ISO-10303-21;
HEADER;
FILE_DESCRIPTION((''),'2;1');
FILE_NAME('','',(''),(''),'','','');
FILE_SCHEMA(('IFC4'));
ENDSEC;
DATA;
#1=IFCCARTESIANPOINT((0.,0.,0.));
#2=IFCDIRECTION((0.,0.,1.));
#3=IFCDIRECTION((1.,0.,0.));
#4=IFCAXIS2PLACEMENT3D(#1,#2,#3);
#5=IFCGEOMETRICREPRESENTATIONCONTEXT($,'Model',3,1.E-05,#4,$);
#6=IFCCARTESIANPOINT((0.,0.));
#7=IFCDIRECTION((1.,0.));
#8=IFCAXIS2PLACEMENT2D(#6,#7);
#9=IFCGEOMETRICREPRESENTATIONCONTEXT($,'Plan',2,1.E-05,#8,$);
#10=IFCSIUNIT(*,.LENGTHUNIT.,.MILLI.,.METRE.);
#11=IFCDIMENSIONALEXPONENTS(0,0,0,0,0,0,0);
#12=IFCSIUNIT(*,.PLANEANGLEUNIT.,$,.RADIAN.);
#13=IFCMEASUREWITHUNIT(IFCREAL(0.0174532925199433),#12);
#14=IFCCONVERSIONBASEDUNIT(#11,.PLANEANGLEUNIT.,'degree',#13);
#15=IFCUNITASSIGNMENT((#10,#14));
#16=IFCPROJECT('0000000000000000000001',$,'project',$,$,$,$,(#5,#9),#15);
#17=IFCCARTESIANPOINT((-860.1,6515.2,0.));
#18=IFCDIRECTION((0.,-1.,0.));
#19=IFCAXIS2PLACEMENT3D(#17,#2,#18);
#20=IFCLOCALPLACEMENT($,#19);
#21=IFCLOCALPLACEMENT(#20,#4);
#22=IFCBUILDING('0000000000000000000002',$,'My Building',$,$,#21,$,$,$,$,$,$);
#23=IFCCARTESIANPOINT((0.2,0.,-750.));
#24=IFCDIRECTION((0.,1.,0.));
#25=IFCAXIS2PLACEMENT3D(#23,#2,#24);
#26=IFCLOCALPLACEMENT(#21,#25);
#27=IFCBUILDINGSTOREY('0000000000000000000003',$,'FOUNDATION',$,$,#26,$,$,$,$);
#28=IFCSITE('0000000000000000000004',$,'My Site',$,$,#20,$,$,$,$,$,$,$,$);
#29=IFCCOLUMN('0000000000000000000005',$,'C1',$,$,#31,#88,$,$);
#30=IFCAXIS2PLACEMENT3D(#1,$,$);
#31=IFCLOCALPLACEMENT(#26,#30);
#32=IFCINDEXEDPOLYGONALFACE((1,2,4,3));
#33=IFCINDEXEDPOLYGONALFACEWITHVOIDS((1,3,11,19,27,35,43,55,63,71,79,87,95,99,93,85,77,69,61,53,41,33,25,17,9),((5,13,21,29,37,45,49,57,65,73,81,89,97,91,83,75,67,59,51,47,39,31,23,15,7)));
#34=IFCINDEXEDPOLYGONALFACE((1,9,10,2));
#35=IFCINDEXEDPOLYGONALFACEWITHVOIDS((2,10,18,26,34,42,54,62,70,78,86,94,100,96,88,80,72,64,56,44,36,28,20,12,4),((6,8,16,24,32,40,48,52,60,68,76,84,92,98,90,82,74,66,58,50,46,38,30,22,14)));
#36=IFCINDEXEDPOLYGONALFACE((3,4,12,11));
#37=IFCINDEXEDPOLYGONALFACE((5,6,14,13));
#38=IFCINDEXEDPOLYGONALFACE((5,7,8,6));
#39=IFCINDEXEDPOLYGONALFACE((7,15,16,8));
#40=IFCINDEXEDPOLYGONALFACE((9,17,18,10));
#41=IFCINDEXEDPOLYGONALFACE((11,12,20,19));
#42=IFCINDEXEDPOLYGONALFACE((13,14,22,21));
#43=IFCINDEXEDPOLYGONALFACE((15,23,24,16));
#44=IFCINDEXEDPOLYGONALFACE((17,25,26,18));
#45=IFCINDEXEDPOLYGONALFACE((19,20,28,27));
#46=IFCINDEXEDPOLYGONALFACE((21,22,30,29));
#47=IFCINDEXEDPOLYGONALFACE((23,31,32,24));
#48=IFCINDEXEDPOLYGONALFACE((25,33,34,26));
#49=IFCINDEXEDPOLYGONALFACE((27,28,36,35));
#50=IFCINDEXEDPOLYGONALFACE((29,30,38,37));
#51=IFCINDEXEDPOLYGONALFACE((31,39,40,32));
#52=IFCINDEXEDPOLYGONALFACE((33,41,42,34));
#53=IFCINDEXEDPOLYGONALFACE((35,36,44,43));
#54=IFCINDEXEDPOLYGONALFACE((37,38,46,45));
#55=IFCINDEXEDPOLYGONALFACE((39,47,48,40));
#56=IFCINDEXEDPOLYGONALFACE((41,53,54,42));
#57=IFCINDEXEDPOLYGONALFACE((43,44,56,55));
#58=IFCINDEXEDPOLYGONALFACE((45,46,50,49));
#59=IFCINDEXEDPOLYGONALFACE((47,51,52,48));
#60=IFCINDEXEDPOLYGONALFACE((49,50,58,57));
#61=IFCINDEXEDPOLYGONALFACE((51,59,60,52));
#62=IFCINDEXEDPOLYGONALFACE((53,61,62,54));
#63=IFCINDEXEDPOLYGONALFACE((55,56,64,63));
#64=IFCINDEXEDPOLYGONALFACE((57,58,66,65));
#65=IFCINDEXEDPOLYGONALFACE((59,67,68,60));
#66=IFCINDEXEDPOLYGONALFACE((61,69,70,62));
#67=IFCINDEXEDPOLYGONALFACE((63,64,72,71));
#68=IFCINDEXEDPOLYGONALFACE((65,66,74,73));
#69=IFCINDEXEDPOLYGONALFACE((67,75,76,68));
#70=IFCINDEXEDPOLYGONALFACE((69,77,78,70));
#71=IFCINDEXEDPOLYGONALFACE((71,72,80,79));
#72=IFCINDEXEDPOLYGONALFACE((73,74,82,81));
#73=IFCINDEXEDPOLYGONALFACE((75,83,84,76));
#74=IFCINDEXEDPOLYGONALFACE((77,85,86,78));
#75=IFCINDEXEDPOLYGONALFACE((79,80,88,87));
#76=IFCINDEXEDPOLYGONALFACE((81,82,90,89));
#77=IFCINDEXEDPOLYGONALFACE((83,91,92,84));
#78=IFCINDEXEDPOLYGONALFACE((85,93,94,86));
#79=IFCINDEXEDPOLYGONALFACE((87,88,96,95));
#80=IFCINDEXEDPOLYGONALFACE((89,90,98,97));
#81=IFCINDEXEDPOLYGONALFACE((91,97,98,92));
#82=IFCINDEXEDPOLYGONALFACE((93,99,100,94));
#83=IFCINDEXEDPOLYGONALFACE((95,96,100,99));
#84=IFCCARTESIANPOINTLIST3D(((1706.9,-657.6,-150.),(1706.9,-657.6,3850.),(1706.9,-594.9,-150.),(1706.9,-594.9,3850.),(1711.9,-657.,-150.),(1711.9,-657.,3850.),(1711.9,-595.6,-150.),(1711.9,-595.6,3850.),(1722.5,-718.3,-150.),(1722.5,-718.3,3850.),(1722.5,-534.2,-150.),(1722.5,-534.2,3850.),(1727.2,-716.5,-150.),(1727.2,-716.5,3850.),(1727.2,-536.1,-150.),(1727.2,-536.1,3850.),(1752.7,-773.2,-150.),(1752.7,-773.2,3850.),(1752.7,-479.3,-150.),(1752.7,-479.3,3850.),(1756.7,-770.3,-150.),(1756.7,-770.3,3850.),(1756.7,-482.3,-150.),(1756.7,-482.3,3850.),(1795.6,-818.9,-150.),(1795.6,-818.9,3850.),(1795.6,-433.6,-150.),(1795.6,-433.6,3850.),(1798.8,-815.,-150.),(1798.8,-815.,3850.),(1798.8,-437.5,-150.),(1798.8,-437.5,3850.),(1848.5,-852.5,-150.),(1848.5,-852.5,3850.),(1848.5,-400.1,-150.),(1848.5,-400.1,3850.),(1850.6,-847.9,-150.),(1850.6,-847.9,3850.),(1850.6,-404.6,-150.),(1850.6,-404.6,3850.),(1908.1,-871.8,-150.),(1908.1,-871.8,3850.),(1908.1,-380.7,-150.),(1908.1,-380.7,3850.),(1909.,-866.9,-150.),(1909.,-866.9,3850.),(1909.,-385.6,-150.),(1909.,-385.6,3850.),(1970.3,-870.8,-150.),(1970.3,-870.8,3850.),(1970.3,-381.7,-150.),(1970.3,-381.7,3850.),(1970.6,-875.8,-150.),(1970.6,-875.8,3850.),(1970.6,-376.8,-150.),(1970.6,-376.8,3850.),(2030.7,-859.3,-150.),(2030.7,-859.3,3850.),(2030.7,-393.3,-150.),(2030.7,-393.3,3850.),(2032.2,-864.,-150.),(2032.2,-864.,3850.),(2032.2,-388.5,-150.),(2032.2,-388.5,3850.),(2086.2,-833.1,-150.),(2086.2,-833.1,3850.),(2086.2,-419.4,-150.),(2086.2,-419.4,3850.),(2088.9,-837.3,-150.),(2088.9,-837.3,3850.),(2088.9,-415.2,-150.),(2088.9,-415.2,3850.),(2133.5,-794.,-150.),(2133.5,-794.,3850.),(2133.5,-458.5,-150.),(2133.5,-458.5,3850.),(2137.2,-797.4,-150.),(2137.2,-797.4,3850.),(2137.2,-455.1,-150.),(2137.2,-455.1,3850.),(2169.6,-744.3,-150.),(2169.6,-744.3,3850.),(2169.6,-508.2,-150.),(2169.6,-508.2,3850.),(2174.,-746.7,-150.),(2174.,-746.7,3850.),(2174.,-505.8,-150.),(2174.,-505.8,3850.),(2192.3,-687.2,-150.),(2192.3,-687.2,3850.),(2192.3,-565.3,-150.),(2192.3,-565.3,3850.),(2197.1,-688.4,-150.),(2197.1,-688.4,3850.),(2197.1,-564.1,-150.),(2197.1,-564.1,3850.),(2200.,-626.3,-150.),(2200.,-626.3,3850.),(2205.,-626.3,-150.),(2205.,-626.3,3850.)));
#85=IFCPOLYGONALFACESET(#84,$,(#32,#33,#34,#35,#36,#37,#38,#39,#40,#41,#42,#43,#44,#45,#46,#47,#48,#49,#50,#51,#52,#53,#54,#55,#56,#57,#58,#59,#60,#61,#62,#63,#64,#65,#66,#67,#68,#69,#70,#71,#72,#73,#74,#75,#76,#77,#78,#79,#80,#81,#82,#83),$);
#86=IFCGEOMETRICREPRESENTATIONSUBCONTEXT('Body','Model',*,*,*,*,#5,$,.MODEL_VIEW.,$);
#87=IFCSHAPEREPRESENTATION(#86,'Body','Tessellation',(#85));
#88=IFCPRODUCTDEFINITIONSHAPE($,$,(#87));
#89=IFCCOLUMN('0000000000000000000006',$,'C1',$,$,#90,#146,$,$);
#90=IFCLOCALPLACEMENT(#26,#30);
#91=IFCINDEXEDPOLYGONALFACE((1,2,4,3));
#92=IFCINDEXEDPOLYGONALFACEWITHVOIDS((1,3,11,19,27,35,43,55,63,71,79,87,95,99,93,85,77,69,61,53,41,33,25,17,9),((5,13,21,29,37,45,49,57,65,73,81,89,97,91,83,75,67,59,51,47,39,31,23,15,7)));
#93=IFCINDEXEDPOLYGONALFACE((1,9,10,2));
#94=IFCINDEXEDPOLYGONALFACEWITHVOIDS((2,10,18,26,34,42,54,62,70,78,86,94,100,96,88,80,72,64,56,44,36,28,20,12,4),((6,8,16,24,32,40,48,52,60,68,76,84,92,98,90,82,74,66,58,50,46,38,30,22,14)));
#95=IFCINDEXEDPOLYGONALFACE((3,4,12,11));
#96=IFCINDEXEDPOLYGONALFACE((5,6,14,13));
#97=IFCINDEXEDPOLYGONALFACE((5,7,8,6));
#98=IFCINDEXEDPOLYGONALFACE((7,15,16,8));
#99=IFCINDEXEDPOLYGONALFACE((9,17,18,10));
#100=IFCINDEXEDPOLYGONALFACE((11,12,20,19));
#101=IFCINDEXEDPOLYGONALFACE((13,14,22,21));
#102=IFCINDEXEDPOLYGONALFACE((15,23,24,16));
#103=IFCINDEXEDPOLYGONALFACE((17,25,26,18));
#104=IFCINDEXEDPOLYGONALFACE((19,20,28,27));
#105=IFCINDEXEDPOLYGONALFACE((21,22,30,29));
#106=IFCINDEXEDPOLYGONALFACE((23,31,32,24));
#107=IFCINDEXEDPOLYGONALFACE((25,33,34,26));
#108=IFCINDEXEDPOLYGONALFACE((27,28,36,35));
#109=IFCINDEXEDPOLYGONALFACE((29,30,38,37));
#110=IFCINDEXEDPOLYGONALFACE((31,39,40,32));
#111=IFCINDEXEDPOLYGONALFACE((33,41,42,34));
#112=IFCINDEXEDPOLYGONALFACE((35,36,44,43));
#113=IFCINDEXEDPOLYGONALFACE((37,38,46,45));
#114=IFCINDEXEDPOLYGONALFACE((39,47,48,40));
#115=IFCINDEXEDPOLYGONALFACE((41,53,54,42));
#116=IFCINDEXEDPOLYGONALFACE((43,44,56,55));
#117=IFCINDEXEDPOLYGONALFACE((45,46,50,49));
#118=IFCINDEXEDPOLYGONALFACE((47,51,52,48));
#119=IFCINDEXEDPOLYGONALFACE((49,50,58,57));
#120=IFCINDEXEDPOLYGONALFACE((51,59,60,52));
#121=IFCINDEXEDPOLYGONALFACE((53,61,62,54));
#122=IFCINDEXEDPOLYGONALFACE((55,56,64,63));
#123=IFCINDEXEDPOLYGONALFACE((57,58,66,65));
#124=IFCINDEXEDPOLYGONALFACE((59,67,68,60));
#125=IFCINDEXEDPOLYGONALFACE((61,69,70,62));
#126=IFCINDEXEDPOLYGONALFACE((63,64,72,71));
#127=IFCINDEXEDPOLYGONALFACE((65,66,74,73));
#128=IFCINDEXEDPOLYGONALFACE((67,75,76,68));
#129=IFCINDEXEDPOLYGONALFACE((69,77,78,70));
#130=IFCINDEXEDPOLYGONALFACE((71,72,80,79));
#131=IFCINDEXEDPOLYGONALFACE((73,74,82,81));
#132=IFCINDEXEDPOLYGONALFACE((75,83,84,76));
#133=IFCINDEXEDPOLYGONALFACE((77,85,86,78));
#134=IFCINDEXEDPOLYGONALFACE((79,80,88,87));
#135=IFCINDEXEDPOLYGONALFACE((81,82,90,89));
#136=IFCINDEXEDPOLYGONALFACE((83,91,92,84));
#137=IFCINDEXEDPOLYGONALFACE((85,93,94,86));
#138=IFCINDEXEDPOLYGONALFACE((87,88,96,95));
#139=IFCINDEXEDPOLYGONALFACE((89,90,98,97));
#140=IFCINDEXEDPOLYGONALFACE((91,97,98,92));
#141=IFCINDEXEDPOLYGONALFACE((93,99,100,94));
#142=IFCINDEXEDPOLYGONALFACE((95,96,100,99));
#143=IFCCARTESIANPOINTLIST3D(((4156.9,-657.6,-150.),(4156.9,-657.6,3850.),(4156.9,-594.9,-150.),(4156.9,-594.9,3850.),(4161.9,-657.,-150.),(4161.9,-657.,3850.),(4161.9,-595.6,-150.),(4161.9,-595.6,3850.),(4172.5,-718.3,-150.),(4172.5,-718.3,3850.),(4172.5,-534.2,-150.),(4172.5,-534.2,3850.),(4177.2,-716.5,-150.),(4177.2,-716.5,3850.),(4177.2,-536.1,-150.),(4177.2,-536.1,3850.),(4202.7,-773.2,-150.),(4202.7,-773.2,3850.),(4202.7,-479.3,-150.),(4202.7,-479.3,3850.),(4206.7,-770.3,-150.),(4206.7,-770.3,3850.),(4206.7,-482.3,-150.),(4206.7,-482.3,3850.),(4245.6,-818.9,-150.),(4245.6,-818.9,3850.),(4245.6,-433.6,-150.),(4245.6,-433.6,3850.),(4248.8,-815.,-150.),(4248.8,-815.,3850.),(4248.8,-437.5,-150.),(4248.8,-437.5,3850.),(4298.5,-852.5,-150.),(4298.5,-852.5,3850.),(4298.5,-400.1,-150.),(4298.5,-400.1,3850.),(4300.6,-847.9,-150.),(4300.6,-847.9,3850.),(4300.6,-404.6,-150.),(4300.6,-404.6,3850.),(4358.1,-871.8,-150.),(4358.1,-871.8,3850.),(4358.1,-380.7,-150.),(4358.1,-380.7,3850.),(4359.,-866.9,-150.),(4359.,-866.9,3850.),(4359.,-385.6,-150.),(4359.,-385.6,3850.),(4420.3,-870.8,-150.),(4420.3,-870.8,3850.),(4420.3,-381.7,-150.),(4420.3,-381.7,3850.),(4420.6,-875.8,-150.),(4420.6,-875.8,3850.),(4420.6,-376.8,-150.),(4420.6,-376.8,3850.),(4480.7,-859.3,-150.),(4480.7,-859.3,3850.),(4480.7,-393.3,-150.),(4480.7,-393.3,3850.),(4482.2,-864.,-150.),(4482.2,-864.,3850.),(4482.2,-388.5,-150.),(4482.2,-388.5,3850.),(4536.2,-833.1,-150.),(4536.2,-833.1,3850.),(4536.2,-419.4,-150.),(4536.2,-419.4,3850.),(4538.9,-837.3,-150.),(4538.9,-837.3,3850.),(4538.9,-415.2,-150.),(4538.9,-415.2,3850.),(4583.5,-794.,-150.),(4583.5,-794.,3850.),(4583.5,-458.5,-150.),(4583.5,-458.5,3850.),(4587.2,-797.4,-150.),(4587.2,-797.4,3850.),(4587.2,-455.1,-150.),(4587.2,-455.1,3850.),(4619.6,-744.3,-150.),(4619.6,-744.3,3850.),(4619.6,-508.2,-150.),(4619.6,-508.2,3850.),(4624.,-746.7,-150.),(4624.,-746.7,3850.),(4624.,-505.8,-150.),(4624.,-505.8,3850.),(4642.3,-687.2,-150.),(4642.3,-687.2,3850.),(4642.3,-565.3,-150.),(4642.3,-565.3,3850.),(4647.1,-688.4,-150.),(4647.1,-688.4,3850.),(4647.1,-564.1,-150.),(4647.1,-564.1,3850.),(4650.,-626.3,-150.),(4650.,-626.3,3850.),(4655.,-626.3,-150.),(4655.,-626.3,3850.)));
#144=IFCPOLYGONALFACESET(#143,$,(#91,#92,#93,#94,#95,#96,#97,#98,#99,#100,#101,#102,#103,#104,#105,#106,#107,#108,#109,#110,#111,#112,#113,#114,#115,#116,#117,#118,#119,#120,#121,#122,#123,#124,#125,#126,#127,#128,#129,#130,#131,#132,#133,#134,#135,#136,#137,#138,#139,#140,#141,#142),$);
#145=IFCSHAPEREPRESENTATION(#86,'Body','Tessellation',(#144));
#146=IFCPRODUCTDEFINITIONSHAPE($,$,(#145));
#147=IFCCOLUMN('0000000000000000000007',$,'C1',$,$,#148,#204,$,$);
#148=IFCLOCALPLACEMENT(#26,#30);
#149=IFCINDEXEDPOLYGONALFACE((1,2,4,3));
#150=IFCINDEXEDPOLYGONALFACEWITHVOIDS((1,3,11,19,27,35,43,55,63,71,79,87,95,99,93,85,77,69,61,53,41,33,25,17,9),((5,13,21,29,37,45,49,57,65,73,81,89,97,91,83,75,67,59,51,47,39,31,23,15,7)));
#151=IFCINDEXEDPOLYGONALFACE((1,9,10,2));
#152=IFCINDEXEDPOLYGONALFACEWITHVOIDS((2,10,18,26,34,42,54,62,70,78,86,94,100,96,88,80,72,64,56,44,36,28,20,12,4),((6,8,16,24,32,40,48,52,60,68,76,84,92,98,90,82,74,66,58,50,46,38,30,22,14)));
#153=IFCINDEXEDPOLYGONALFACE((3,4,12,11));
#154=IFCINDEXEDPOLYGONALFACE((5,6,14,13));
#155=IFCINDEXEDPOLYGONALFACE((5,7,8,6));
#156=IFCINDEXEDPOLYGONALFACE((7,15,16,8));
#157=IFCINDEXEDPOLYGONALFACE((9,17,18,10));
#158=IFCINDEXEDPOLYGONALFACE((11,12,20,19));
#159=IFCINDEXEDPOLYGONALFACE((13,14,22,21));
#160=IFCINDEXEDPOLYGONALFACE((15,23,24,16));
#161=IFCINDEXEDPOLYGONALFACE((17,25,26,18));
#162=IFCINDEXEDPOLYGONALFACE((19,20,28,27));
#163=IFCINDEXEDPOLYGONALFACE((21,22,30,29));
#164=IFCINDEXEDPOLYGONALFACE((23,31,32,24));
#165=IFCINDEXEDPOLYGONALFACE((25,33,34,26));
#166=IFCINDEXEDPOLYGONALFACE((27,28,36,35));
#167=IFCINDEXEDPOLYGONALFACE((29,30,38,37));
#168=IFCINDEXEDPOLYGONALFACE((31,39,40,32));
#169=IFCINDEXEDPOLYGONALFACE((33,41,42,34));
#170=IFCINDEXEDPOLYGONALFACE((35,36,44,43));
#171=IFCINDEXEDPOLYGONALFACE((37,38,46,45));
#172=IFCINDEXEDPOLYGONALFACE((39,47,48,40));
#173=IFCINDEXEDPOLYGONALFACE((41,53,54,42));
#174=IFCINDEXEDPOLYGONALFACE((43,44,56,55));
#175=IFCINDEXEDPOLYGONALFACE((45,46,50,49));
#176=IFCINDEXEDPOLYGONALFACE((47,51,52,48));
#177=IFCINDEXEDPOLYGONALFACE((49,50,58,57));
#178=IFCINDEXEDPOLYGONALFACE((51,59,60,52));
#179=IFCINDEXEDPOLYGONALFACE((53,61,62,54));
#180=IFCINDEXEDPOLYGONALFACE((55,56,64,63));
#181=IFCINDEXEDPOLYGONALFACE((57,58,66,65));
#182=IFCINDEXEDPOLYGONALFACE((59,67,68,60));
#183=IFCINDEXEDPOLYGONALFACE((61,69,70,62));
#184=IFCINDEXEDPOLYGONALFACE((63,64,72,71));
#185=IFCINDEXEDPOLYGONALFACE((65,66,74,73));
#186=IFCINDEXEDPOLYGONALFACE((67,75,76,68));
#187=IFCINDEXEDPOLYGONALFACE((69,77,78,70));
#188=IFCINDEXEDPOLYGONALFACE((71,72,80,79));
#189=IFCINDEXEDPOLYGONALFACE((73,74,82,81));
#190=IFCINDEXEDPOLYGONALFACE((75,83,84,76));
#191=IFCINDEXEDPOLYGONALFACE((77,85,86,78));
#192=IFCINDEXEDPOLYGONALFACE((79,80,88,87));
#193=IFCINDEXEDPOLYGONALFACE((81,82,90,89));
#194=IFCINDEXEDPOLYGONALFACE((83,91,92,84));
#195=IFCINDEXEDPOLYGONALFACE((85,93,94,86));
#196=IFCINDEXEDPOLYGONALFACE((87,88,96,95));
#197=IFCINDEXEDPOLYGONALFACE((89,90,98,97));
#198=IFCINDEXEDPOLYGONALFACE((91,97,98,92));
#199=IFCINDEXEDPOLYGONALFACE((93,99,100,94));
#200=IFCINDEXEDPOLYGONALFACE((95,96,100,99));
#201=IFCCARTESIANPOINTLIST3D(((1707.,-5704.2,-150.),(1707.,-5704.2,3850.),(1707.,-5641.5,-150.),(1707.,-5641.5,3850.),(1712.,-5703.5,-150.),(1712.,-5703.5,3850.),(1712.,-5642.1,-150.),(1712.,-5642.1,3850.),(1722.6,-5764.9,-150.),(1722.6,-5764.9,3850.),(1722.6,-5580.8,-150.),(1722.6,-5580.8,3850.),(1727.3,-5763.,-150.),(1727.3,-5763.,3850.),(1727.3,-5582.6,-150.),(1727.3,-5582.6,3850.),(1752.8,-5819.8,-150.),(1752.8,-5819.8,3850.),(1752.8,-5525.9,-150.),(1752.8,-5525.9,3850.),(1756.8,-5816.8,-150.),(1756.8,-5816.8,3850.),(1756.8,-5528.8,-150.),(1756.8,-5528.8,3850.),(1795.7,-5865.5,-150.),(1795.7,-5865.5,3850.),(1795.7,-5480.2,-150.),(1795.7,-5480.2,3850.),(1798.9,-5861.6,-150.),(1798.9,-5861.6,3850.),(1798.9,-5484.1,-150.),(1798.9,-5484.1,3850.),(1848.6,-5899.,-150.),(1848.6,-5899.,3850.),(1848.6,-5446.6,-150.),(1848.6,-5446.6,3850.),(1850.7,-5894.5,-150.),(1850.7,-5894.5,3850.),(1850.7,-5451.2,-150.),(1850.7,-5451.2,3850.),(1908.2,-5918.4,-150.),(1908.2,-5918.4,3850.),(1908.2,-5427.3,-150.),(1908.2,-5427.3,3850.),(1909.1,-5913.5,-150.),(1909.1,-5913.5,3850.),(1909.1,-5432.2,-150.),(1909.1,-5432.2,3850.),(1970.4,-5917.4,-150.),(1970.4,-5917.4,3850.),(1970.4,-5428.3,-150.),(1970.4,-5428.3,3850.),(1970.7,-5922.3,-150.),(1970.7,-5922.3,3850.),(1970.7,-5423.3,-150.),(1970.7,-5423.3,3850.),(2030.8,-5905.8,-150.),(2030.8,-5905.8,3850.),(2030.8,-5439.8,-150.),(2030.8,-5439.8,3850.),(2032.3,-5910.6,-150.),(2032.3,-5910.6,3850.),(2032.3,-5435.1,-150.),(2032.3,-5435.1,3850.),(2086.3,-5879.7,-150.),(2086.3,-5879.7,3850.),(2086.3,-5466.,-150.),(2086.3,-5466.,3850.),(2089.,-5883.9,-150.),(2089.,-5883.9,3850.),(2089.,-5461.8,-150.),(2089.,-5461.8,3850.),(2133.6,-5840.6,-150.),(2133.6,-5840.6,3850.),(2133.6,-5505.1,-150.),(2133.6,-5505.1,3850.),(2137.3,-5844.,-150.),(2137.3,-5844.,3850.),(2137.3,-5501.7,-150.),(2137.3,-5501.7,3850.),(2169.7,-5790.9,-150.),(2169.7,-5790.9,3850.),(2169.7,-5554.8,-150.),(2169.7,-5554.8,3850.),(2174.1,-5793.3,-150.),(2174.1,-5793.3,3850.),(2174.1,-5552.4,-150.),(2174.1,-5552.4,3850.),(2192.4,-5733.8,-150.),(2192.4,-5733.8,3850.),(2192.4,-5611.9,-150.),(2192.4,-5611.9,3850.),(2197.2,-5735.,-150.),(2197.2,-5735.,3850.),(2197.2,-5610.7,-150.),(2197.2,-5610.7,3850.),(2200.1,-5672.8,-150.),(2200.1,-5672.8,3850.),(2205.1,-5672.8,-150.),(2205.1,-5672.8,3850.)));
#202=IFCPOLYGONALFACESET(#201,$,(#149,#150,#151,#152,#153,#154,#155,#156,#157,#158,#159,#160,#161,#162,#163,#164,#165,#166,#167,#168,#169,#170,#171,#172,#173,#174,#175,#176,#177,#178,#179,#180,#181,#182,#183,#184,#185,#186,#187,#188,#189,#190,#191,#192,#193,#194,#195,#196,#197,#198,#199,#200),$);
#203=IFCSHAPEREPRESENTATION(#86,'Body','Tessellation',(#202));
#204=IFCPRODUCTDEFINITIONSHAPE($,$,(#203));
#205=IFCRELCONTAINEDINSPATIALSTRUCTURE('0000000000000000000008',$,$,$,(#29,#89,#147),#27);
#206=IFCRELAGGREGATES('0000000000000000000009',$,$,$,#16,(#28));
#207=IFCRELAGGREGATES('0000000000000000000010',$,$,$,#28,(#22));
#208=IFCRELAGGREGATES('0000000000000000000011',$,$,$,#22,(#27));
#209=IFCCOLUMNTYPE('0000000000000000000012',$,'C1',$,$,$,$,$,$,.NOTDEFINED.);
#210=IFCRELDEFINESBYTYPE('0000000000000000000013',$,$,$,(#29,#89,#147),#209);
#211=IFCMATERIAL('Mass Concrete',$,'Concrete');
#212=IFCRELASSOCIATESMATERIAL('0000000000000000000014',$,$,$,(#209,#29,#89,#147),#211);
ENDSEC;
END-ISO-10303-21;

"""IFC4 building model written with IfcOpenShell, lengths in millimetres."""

from ifc_helpers import new_model, entity, si_unit, converted_unit, frame, origin_with_axes, origin_2d_with_axis, place, context, subcontext, project, spatial, rectangle, hollow_circle, extrude, material, material_profile, profile_set, profile_usage, type_object, element, save


model = new_model("IFC4")

# Units and contexts
model_context = context("Model", 3, precision=1e-05, world=origin_with_axes())
plan_context = context("Plan", 2, precision=1e-05, world=origin_2d_with_axis())
body_context = subcontext(model_context, "Body", "Model", "MODEL_VIEW")
ifc_project = project(units=[si_unit("LENGTHUNIT", "METRE", prefix="MILLI"), converted_unit("PLANEANGLEUNIT", "degree", entity("IfcReal", 0.0174532925199433), si_unit("PLANEANGLEUNIT", "RADIAN"), dimensions=[0, 0, 0, 0, 0, 0, 0])], contexts=[model_context, plan_context])

# Site, building, storey
site_placement = place(None, frame((-860.1, 6515.2, 0.0), z_axis=(0.0, 0.0, 1.0), x_axis=(0.0, -1.0, 0.0)))
site = spatial("IfcSite", under=ifc_project, at=site_placement, Name="My Site")
building_placement = place(site_placement, frame((0.0, 0.0, 0.0), z_axis=(0.0, 0.0, 1.0), x_axis=(1.0, 0.0, 0.0)))
building = spatial("IfcBuilding", under=site, at=building_placement, Name="My Building")
storey_placement = place(building_placement, frame((0.2, 0.0, -750.0), z_axis=(0.0, 0.0, 1.0), x_axis=(0.0, 1.0, 0.0)))
storey = spatial("IfcBuildingStorey", under=building, at=storey_placement, Name="FOUNDATION")

# Shared definitions
ifc_material_1 = material(Name="Mass Concrete", Category="Concrete")

# Columns
ifc_material_profile = material_profile(ifc_material_1, rectangle(XDim=150.0, YDim=150.0), Name="Square Column", Category="Structure", Priority=1)
ifc_profile_set = profile_set([ifc_material_profile], Name="RC_COL_150x150")
column_type = type_object("IfcColumnType", Name="C1", PredefinedType="NOTDEFINED", material=ifc_profile_set)
ifc_profile_usage_1 = profile_usage(ifc_profile_set, cardinal=5)
column_1_placement = place(storey_placement, frame((1955.0, -626.3, -150.0), z_axis=(0.0, 0.0, 1.0), x_axis=(1.0, 0.0, 0.0)))
element("IfcColumn", 1, at=column_1_placement, inside=storey, type_object=column_type, material=ifc_profile_usage_1, Name="C1", context=body_context, shape_type="SweptSolid", body=[
    extrude(hollow_circle(Radius=250.0, WallThickness=5.0), origin_with_axes(), (0.0, 0.0, 1.0), 4000.0),
])
ifc_profile_usage_2 = profile_usage(ifc_profile_set, cardinal=5)
column_2_placement = place(storey_placement, frame((4405.0, -626.3, -150.0), z_axis=(0.0, 0.0, 1.0), x_axis=(1.0, 0.0, 0.0)))
element("IfcColumn", 2, at=column_2_placement, inside=storey, type_object=column_type, material=ifc_profile_usage_2, Name="C1", context=body_context, shape_type="SweptSolid", body=[
    extrude(hollow_circle(Radius=250.0, WallThickness=5.0), origin_with_axes(), (0.0, 0.0, 1.0), 4000.0),
])
ifc_profile_usage_3 = profile_usage(ifc_profile_set, cardinal=5)
column_3_placement = place(storey_placement, frame((1955.1, -5672.8, -150.0), z_axis=(0.0, 0.0, 1.0), x_axis=(1.0, 0.0, 0.0)))
element("IfcColumn", 3, at=column_3_placement, inside=storey, type_object=column_type, material=ifc_profile_usage_3, Name="C1", context=body_context, shape_type="SweptSolid", body=[
    extrude(hollow_circle(Radius=250.0, WallThickness=5.0), origin_with_axes(), (0.0, 0.0, 1.0), 4000.0),
])

save(model, "model.ifc")
